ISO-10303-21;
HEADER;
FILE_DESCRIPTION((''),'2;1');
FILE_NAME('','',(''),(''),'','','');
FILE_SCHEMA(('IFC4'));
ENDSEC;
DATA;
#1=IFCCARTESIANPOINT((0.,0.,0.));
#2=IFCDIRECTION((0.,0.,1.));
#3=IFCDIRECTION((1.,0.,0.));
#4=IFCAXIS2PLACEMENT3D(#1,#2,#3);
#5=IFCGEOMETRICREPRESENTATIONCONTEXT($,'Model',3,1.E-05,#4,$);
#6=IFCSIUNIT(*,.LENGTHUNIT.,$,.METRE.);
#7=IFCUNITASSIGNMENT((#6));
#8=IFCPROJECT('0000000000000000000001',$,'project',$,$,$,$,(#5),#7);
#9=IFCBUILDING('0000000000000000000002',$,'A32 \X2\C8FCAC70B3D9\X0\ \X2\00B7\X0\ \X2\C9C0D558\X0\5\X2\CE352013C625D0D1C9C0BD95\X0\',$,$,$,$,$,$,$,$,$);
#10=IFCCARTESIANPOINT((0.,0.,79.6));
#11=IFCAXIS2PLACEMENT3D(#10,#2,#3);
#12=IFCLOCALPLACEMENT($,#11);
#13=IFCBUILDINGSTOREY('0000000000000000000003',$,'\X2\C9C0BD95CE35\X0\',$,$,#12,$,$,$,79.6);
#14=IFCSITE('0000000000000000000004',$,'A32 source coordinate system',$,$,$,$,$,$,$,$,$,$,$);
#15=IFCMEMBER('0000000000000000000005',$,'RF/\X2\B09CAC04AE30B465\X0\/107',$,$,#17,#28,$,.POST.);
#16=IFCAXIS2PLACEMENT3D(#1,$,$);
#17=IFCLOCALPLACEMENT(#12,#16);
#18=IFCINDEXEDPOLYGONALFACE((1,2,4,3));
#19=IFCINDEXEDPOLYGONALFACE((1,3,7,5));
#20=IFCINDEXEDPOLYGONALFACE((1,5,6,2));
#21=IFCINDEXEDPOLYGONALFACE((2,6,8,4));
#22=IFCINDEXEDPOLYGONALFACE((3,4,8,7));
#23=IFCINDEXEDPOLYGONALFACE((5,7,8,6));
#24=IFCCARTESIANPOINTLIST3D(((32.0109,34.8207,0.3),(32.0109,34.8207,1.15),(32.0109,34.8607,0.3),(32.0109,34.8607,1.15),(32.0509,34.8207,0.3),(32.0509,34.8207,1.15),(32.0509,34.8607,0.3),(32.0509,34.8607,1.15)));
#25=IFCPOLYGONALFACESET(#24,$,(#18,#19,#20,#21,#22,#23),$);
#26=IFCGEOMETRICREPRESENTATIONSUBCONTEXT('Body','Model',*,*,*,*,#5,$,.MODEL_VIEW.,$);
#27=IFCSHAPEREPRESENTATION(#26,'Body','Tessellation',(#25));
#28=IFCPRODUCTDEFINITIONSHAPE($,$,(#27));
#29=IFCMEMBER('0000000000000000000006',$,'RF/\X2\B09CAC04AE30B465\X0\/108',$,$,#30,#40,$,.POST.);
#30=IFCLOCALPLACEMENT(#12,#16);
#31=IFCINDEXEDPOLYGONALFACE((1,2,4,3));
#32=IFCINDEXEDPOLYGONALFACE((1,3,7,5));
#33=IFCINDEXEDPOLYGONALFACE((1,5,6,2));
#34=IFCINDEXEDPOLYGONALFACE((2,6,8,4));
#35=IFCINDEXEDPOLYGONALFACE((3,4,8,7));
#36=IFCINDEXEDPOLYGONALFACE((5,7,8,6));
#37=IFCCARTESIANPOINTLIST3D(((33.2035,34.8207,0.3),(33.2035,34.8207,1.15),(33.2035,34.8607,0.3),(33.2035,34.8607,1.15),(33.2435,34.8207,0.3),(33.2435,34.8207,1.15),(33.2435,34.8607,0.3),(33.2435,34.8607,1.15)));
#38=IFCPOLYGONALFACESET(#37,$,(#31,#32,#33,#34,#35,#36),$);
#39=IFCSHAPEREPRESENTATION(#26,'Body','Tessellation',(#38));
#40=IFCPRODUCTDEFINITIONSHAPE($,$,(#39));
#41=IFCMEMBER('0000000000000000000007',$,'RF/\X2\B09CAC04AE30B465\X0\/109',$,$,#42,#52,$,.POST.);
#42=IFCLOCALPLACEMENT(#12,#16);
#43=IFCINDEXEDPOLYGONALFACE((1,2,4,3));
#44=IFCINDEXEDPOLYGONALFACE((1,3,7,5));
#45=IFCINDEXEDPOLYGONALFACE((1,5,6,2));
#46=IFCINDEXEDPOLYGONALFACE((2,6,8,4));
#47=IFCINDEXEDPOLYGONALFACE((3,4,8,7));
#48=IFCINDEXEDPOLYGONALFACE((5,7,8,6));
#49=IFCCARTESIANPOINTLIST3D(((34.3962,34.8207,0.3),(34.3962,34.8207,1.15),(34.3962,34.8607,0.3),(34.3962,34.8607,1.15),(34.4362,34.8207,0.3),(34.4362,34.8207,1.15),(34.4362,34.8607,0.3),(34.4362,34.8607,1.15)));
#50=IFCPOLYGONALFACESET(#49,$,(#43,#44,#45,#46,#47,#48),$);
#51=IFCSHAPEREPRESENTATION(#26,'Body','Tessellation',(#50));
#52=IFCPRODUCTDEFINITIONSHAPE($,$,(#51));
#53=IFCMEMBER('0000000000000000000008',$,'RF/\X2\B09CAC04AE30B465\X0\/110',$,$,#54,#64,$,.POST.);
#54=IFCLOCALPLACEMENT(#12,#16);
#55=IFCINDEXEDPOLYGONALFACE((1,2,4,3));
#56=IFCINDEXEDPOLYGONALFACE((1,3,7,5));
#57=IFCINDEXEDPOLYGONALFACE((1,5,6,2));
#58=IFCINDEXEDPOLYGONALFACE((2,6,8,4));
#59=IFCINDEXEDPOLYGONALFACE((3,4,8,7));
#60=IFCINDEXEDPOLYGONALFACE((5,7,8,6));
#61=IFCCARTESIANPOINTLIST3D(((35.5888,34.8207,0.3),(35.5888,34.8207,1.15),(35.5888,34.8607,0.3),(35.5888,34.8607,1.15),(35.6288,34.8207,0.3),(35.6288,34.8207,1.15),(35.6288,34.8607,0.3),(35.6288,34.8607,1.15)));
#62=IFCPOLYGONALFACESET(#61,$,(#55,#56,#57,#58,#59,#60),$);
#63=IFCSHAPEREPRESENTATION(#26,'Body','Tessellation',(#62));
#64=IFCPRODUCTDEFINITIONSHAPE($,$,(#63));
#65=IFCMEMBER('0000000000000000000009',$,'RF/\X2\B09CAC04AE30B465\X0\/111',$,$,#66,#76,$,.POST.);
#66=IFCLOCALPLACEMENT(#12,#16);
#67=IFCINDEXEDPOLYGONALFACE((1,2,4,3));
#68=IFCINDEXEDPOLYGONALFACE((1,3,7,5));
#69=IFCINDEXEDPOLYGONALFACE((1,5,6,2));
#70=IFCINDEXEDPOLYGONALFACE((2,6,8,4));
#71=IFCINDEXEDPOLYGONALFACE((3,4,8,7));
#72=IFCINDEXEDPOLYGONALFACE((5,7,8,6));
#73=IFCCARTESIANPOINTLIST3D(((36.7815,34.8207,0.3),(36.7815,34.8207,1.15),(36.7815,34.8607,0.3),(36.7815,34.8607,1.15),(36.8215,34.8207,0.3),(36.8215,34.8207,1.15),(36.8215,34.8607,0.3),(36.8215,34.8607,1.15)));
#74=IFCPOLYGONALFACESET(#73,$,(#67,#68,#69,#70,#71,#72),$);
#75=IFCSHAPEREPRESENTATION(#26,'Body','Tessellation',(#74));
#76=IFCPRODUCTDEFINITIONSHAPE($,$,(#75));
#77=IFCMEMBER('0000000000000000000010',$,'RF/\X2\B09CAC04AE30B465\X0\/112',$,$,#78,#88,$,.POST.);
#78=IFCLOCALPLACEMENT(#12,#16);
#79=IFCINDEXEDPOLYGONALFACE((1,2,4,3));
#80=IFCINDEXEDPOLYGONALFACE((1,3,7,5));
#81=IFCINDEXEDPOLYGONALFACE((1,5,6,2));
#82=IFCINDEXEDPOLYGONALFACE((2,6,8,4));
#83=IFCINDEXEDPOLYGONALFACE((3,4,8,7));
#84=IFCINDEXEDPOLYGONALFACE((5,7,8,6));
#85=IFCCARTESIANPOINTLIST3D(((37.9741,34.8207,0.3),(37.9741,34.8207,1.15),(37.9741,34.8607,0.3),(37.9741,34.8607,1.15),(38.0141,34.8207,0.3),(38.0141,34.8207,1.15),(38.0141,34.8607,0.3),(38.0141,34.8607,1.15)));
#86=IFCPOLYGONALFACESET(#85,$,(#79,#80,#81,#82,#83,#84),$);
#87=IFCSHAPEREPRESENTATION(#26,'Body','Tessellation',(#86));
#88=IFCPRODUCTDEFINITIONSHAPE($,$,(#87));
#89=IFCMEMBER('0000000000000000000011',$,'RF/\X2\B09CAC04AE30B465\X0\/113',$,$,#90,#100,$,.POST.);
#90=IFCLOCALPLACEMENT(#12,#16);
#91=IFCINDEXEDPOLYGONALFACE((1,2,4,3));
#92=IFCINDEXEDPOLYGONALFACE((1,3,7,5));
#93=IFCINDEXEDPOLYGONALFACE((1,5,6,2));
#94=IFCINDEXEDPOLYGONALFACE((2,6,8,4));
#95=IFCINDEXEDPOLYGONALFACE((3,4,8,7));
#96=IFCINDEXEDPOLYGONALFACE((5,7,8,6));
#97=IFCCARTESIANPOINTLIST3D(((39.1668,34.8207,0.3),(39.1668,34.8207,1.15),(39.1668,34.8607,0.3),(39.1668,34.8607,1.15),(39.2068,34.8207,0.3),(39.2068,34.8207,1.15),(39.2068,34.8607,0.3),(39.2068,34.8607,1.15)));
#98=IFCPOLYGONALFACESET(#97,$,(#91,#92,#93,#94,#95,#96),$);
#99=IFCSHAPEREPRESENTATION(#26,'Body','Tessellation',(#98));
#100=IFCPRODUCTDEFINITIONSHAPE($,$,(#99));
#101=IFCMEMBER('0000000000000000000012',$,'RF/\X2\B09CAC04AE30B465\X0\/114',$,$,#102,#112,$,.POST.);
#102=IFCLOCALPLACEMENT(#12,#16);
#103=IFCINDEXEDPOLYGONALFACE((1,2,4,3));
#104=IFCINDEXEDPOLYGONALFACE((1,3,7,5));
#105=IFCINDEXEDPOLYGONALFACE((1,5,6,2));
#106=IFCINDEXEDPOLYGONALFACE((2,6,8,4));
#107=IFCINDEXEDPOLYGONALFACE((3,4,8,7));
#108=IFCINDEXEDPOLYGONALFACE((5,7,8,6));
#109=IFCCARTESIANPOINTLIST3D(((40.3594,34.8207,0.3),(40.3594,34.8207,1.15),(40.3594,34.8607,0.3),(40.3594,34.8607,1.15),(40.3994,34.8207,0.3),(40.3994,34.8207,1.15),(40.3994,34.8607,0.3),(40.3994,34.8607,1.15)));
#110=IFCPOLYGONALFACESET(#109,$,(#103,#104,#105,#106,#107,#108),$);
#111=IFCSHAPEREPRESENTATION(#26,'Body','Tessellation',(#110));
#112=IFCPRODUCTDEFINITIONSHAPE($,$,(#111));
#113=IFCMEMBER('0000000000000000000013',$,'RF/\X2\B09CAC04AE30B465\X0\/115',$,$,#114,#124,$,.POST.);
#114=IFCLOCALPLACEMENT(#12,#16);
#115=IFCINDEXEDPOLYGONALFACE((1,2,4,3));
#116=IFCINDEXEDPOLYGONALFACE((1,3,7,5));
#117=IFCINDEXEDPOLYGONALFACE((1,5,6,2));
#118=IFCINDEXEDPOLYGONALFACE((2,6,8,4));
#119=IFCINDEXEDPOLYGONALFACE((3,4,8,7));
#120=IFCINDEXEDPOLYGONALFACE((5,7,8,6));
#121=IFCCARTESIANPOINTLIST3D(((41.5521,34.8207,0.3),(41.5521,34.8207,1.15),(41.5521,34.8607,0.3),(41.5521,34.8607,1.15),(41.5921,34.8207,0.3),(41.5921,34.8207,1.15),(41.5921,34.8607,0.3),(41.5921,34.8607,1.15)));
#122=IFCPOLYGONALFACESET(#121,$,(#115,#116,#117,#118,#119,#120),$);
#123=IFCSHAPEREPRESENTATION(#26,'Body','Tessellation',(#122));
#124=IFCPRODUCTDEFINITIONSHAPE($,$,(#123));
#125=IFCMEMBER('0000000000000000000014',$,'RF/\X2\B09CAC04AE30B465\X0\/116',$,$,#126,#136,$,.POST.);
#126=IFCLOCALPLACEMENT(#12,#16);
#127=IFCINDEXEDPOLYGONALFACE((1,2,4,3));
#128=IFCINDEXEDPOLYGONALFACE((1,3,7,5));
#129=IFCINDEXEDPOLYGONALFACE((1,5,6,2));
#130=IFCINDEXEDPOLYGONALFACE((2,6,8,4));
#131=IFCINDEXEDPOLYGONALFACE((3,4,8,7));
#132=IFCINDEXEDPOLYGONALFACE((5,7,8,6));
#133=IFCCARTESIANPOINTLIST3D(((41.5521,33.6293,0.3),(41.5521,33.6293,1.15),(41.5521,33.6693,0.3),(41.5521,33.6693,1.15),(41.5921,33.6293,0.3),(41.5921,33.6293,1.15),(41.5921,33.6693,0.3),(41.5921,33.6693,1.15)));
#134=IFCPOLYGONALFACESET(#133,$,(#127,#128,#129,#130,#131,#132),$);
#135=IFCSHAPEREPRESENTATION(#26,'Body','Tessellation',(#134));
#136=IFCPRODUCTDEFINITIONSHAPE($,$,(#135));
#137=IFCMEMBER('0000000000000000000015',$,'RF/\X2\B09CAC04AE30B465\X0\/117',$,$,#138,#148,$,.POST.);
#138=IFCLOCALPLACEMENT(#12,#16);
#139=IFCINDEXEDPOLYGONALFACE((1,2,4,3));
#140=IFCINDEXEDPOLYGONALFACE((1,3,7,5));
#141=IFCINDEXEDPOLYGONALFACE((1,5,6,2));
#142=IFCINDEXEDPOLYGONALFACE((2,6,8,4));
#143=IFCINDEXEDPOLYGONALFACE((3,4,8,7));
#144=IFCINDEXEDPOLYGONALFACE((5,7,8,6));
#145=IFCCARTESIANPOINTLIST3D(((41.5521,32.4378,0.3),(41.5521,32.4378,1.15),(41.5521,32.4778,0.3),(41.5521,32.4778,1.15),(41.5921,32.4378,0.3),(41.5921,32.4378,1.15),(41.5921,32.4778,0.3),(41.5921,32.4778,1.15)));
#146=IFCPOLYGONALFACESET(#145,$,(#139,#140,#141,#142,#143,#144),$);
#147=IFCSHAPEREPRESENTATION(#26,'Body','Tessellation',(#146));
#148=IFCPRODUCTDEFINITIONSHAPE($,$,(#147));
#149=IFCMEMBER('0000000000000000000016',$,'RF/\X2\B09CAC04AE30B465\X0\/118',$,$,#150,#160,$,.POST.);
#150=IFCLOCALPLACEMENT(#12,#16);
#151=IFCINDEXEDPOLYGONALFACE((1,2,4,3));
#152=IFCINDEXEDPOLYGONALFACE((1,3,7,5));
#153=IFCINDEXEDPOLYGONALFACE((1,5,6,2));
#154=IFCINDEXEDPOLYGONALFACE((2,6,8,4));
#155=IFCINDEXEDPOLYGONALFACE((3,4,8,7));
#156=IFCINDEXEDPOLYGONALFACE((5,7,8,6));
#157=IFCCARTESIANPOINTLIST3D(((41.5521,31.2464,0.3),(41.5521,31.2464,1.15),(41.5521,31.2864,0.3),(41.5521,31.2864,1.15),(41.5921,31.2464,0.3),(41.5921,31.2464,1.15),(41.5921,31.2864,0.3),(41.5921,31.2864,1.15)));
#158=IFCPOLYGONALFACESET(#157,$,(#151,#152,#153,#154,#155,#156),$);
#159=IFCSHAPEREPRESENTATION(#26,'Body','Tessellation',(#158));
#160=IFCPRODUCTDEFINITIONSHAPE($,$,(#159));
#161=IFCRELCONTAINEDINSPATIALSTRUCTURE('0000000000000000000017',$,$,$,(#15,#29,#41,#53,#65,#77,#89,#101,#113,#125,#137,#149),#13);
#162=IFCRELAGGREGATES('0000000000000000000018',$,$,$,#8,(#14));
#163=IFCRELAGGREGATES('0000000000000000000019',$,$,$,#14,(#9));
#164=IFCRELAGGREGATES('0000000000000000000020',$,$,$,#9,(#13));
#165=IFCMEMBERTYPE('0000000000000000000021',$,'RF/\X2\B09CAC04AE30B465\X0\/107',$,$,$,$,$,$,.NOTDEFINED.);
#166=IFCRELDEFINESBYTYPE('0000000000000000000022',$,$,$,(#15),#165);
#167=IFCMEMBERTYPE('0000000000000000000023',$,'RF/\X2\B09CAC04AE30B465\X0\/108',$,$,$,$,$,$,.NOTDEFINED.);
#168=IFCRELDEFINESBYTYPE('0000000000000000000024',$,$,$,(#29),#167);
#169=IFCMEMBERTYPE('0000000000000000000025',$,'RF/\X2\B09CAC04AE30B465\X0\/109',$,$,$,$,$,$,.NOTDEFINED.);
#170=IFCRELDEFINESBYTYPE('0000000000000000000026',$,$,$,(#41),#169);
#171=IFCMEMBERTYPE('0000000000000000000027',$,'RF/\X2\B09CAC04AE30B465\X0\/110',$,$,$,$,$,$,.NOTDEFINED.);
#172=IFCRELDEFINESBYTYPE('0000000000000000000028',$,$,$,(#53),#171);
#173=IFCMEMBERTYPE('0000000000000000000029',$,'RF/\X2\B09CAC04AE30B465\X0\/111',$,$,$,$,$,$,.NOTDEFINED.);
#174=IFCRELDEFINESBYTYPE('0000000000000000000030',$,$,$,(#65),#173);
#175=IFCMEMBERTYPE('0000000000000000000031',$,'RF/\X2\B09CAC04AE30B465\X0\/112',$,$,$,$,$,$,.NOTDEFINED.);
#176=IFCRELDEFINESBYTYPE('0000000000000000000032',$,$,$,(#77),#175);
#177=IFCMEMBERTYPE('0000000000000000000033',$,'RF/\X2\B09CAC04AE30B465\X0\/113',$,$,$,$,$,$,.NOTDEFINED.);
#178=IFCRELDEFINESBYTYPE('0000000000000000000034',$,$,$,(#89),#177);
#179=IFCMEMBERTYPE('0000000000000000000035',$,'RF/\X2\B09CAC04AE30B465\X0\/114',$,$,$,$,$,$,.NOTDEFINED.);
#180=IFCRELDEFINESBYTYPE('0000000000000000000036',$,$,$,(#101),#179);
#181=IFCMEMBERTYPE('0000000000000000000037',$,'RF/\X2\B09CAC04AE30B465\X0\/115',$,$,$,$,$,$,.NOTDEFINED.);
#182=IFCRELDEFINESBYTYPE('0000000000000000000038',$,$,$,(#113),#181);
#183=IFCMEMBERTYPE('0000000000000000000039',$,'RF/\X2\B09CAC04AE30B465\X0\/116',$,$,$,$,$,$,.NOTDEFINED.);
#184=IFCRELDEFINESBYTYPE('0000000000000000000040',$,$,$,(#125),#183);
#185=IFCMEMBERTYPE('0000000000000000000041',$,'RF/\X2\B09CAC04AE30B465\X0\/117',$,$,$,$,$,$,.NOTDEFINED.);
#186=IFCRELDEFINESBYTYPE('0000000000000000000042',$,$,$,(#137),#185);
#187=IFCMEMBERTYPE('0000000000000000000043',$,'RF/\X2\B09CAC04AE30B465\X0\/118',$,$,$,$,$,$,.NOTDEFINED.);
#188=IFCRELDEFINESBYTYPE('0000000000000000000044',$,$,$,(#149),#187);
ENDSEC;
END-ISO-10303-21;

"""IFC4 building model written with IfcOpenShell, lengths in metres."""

from ifc_helpers import new_model, si_unit, frame, origin, origin_with_axes, place, context, subcontext, project, spatial, polyline, outline, extrude, source, transform, mapped, type_object, type_shapes, element, save


model = new_model("IFC4")

# Units and contexts
model_context = context("Model", 3, precision=1e-05, world=origin_with_axes())
body_context = subcontext(model_context, "Body", "Model", "MODEL_VIEW")
ifc_project = project(units=[si_unit("LENGTHUNIT", "METRE")], contexts=[model_context])

# Site, building, storey
site = spatial("IfcSite", under=ifc_project, Name="A32 source coordinate system")
building = spatial("IfcBuilding", under=site, Name="A32 주거동 · 지하5층–옥탑지붕")
storey_placement = place(None, frame((0.0, 0.0, 79.6), z_axis=(0.0, 0.0, 1.0), x_axis=(1.0, 0.0, 0.0)))
storey = spatial("IfcBuildingStorey", under=building, at=storey_placement, Name="지붕층", Elevation=79.6)

# Members
member_type_1 = type_object("IfcMemberType", Name="RF/난간기둥/107", PredefinedType="NOTDEFINED")
shared_shape_1 = source(origin(), body_context, "Body", "SweptSolid", [
    extrude(outline(polyline([(32.0509, 34.8207), (32.0109, 34.8207), (32.0109, 34.8607), (32.0509, 34.8607), (32.0509, 34.8207)])), frame((0.0, 0.0, 0.3)), (0.0, 0.0, 1.0), 0.85),
])
type_shapes(member_type_1, [shared_shape_1])
member_1_placement = place(storey_placement, origin_with_axes())
element("IfcMember", 1, at=member_1_placement, inside=storey, type_object=member_type_1, Name="RF/난간기둥/107", PredefinedType="POST", context=body_context, shape_type="MappedRepresentation", body=[
    mapped(shared_shape_1, transform((0.0, 0.0, 0.0), scale=1.0)),
])
member_type_2 = type_object("IfcMemberType", Name="RF/난간기둥/108", PredefinedType="NOTDEFINED")
shared_shape_2 = source(origin(), body_context, "Body", "SweptSolid", [
    extrude(outline(polyline([(33.2435, 34.8207), (33.2035, 34.8207), (33.2035, 34.8607), (33.2435, 34.8607), (33.2435, 34.8207)])), frame((0.0, 0.0, 0.3)), (0.0, 0.0, 1.0), 0.85),
])
type_shapes(member_type_2, [shared_shape_2])
member_2_placement = place(storey_placement, origin_with_axes())
element("IfcMember", 2, at=member_2_placement, inside=storey, type_object=member_type_2, Name="RF/난간기둥/108", PredefinedType="POST", context=body_context, shape_type="MappedRepresentation", body=[
    mapped(shared_shape_2, transform((0.0, 0.0, 0.0), scale=1.0)),
])
member_type_3 = type_object("IfcMemberType", Name="RF/난간기둥/109", PredefinedType="NOTDEFINED")
shared_shape_3 = source(origin(), body_context, "Body", "SweptSolid", [
    extrude(outline(polyline([(34.4362, 34.8207), (34.3962, 34.8207), (34.3962, 34.8607), (34.4362, 34.8607), (34.4362, 34.8207)])), frame((0.0, 0.0, 0.3)), (0.0, 0.0, 1.0), 0.85),
])
type_shapes(member_type_3, [shared_shape_3])
member_3_placement = place(storey_placement, origin_with_axes())
element("IfcMember", 3, at=member_3_placement, inside=storey, type_object=member_type_3, Name="RF/난간기둥/109", PredefinedType="POST", context=body_context, shape_type="MappedRepresentation", body=[
    mapped(shared_shape_3, transform((0.0, 0.0, 0.0), scale=1.0)),
])
member_type_4 = type_object("IfcMemberType", Name="RF/난간기둥/110", PredefinedType="NOTDEFINED")
shared_shape_4 = source(origin(), body_context, "Body", "SweptSolid", [
    extrude(outline(polyline([(35.6288, 34.8207), (35.5888, 34.8207), (35.5888, 34.8607), (35.6288, 34.8607), (35.6288, 34.8207)])), frame((0.0, 0.0, 0.3)), (0.0, 0.0, 1.0), 0.85),
])
type_shapes(member_type_4, [shared_shape_4])
member_4_placement = place(storey_placement, origin_with_axes())
element("IfcMember", 4, at=member_4_placement, inside=storey, type_object=member_type_4, Name="RF/난간기둥/110", PredefinedType="POST", context=body_context, shape_type="MappedRepresentation", body=[
    mapped(shared_shape_4, transform((0.0, 0.0, 0.0), scale=1.0)),
])
member_type_5 = type_object("IfcMemberType", Name="RF/난간기둥/111", PredefinedType="NOTDEFINED")
shared_shape_5 = source(origin(), body_context, "Body", "SweptSolid", [
    extrude(outline(polyline([(36.8215, 34.8207), (36.7815, 34.8207), (36.7815, 34.8607), (36.8215, 34.8607), (36.8215, 34.8207)])), frame((0.0, 0.0, 0.3)), (0.0, 0.0, 1.0), 0.85),
])
type_shapes(member_type_5, [shared_shape_5])
member_5_placement = place(storey_placement, origin_with_axes())
element("IfcMember", 5, at=member_5_placement, inside=storey, type_object=member_type_5, Name="RF/난간기둥/111", PredefinedType="POST", context=body_context, shape_type="MappedRepresentation", body=[
    mapped(shared_shape_5, transform((0.0, 0.0, 0.0), scale=1.0)),
])
member_type_6 = type_object("IfcMemberType", Name="RF/난간기둥/112", PredefinedType="NOTDEFINED")
shared_shape_6 = source(origin(), body_context, "Body", "SweptSolid", [
    extrude(outline(polyline([(38.0141, 34.8207), (37.9741, 34.8207), (37.9741, 34.8607), (38.0141, 34.8607), (38.0141, 34.8207)])), frame((0.0, 0.0, 0.3)), (0.0, 0.0, 1.0), 0.85),
])
type_shapes(member_type_6, [shared_shape_6])
member_6_placement = place(storey_placement, origin_with_axes())
element("IfcMember", 6, at=member_6_placement, inside=storey, type_object=member_type_6, Name="RF/난간기둥/112", PredefinedType="POST", context=body_context, shape_type="MappedRepresentation", body=[
    mapped(shared_shape_6, transform((0.0, 0.0, 0.0), scale=1.0)),
])
member_type_7 = type_object("IfcMemberType", Name="RF/난간기둥/113", PredefinedType="NOTDEFINED")
shared_shape_7 = source(origin(), body_context, "Body", "SweptSolid", [
    extrude(outline(polyline([(39.2068, 34.8207), (39.1668, 34.8207), (39.1668, 34.8607), (39.2068, 34.8607), (39.2068, 34.8207)])), frame((0.0, 0.0, 0.3)), (0.0, 0.0, 1.0), 0.85),
])
type_shapes(member_type_7, [shared_shape_7])
member_7_placement = place(storey_placement, origin_with_axes())
element("IfcMember", 7, at=member_7_placement, inside=storey, type_object=member_type_7, Name="RF/난간기둥/113", PredefinedType="POST", context=body_context, shape_type="MappedRepresentation", body=[
    mapped(shared_shape_7, transform((0.0, 0.0, 0.0), scale=1.0)),
])
member_type_8 = type_object("IfcMemberType", Name="RF/난간기둥/114", PredefinedType="NOTDEFINED")
shared_shape_8 = source(origin(), body_context, "Body", "SweptSolid", [
    extrude(outline(polyline([(40.3994, 34.8207), (40.3594, 34.8207), (40.3594, 34.8607), (40.3994, 34.8607), (40.3994, 34.8207)])), frame((0.0, 0.0, 0.3)), (0.0, 0.0, 1.0), 0.85),
])
type_shapes(member_type_8, [shared_shape_8])
member_8_placement = place(storey_placement, origin_with_axes())
element("IfcMember", 8, at=member_8_placement, inside=storey, type_object=member_type_8, Name="RF/난간기둥/114", PredefinedType="POST", context=body_context, shape_type="MappedRepresentation", body=[
    mapped(shared_shape_8, transform((0.0, 0.0, 0.0), scale=1.0)),
])
member_type_9 = type_object("IfcMemberType", Name="RF/난간기둥/115", PredefinedType="NOTDEFINED")
shared_shape_9 = source(origin(), body_context, "Body", "SweptSolid", [
    extrude(outline(polyline([(41.5921, 34.8207), (41.5521, 34.8207), (41.5521, 34.8607), (41.5921, 34.8607), (41.5921, 34.8207)])), frame((0.0, 0.0, 0.3)), (0.0, 0.0, 1.0), 0.85),
])
type_shapes(member_type_9, [shared_shape_9])
member_9_placement = place(storey_placement, origin_with_axes())
element("IfcMember", 9, at=member_9_placement, inside=storey, type_object=member_type_9, Name="RF/난간기둥/115", PredefinedType="POST", context=body_context, shape_type="MappedRepresentation", body=[
    mapped(shared_shape_9, transform((0.0, 0.0, 0.0), scale=1.0)),
])
member_type_10 = type_object("IfcMemberType", Name="RF/난간기둥/116", PredefinedType="NOTDEFINED")
shared_shape_10 = source(origin(), body_context, "Body", "SweptSolid", [
    extrude(outline(polyline([(41.5921, 33.6293), (41.5521, 33.6293), (41.5521, 33.6693), (41.5921, 33.6693), (41.5921, 33.6293)])), frame((0.0, 0.0, 0.3)), (0.0, 0.0, 1.0), 0.85),
])
type_shapes(member_type_10, [shared_shape_10])
member_10_placement = place(storey_placement, origin_with_axes())
element("IfcMember", 10, at=member_10_placement, inside=storey, type_object=member_type_10, Name="RF/난간기둥/116", PredefinedType="POST", context=body_context, shape_type="MappedRepresentation", body=[
    mapped(shared_shape_10, transform((0.0, 0.0, 0.0), scale=1.0)),
])
member_type_11 = type_object("IfcMemberType", Name="RF/난간기둥/117", PredefinedType="NOTDEFINED")
shared_shape_11 = source(origin(), body_context, "Body", "SweptSolid", [
    extrude(outline(polyline([(41.5921, 32.4378), (41.5521, 32.4378), (41.5521, 32.4778), (41.5921, 32.4778), (41.5921, 32.4378)])), frame((0.0, 0.0, 0.3)), (0.0, 0.0, 1.0), 0.85),
])
type_shapes(member_type_11, [shared_shape_11])
member_11_placement = place(storey_placement, origin_with_axes())
element("IfcMember", 11, at=member_11_placement, inside=storey, type_object=member_type_11, Name="RF/난간기둥/117", PredefinedType="POST", context=body_context, shape_type="MappedRepresentation", body=[
    mapped(shared_shape_11, transform((0.0, 0.0, 0.0), scale=1.0)),
])
member_type_12 = type_object("IfcMemberType", Name="RF/난간기둥/118", PredefinedType="NOTDEFINED")
shared_shape_12 = source(origin(), body_context, "Body", "SweptSolid", [
    extrude(outline(polyline([(41.5921, 31.2464), (41.5521, 31.2464), (41.5521, 31.2864), (41.5921, 31.2864), (41.5921, 31.2464)])), frame((0.0, 0.0, 0.3)), (0.0, 0.0, 1.0), 0.85),
])
type_shapes(member_type_12, [shared_shape_12])
member_12_placement = place(storey_placement, origin_with_axes())
element("IfcMember", 12, at=member_12_placement, inside=storey, type_object=member_type_12, Name="RF/난간기둥/118", PredefinedType="POST", context=body_context, shape_type="MappedRepresentation", body=[
    mapped(shared_shape_12, transform((0.0, 0.0, 0.0), scale=1.0)),
])

save(model, "model.ifc")
